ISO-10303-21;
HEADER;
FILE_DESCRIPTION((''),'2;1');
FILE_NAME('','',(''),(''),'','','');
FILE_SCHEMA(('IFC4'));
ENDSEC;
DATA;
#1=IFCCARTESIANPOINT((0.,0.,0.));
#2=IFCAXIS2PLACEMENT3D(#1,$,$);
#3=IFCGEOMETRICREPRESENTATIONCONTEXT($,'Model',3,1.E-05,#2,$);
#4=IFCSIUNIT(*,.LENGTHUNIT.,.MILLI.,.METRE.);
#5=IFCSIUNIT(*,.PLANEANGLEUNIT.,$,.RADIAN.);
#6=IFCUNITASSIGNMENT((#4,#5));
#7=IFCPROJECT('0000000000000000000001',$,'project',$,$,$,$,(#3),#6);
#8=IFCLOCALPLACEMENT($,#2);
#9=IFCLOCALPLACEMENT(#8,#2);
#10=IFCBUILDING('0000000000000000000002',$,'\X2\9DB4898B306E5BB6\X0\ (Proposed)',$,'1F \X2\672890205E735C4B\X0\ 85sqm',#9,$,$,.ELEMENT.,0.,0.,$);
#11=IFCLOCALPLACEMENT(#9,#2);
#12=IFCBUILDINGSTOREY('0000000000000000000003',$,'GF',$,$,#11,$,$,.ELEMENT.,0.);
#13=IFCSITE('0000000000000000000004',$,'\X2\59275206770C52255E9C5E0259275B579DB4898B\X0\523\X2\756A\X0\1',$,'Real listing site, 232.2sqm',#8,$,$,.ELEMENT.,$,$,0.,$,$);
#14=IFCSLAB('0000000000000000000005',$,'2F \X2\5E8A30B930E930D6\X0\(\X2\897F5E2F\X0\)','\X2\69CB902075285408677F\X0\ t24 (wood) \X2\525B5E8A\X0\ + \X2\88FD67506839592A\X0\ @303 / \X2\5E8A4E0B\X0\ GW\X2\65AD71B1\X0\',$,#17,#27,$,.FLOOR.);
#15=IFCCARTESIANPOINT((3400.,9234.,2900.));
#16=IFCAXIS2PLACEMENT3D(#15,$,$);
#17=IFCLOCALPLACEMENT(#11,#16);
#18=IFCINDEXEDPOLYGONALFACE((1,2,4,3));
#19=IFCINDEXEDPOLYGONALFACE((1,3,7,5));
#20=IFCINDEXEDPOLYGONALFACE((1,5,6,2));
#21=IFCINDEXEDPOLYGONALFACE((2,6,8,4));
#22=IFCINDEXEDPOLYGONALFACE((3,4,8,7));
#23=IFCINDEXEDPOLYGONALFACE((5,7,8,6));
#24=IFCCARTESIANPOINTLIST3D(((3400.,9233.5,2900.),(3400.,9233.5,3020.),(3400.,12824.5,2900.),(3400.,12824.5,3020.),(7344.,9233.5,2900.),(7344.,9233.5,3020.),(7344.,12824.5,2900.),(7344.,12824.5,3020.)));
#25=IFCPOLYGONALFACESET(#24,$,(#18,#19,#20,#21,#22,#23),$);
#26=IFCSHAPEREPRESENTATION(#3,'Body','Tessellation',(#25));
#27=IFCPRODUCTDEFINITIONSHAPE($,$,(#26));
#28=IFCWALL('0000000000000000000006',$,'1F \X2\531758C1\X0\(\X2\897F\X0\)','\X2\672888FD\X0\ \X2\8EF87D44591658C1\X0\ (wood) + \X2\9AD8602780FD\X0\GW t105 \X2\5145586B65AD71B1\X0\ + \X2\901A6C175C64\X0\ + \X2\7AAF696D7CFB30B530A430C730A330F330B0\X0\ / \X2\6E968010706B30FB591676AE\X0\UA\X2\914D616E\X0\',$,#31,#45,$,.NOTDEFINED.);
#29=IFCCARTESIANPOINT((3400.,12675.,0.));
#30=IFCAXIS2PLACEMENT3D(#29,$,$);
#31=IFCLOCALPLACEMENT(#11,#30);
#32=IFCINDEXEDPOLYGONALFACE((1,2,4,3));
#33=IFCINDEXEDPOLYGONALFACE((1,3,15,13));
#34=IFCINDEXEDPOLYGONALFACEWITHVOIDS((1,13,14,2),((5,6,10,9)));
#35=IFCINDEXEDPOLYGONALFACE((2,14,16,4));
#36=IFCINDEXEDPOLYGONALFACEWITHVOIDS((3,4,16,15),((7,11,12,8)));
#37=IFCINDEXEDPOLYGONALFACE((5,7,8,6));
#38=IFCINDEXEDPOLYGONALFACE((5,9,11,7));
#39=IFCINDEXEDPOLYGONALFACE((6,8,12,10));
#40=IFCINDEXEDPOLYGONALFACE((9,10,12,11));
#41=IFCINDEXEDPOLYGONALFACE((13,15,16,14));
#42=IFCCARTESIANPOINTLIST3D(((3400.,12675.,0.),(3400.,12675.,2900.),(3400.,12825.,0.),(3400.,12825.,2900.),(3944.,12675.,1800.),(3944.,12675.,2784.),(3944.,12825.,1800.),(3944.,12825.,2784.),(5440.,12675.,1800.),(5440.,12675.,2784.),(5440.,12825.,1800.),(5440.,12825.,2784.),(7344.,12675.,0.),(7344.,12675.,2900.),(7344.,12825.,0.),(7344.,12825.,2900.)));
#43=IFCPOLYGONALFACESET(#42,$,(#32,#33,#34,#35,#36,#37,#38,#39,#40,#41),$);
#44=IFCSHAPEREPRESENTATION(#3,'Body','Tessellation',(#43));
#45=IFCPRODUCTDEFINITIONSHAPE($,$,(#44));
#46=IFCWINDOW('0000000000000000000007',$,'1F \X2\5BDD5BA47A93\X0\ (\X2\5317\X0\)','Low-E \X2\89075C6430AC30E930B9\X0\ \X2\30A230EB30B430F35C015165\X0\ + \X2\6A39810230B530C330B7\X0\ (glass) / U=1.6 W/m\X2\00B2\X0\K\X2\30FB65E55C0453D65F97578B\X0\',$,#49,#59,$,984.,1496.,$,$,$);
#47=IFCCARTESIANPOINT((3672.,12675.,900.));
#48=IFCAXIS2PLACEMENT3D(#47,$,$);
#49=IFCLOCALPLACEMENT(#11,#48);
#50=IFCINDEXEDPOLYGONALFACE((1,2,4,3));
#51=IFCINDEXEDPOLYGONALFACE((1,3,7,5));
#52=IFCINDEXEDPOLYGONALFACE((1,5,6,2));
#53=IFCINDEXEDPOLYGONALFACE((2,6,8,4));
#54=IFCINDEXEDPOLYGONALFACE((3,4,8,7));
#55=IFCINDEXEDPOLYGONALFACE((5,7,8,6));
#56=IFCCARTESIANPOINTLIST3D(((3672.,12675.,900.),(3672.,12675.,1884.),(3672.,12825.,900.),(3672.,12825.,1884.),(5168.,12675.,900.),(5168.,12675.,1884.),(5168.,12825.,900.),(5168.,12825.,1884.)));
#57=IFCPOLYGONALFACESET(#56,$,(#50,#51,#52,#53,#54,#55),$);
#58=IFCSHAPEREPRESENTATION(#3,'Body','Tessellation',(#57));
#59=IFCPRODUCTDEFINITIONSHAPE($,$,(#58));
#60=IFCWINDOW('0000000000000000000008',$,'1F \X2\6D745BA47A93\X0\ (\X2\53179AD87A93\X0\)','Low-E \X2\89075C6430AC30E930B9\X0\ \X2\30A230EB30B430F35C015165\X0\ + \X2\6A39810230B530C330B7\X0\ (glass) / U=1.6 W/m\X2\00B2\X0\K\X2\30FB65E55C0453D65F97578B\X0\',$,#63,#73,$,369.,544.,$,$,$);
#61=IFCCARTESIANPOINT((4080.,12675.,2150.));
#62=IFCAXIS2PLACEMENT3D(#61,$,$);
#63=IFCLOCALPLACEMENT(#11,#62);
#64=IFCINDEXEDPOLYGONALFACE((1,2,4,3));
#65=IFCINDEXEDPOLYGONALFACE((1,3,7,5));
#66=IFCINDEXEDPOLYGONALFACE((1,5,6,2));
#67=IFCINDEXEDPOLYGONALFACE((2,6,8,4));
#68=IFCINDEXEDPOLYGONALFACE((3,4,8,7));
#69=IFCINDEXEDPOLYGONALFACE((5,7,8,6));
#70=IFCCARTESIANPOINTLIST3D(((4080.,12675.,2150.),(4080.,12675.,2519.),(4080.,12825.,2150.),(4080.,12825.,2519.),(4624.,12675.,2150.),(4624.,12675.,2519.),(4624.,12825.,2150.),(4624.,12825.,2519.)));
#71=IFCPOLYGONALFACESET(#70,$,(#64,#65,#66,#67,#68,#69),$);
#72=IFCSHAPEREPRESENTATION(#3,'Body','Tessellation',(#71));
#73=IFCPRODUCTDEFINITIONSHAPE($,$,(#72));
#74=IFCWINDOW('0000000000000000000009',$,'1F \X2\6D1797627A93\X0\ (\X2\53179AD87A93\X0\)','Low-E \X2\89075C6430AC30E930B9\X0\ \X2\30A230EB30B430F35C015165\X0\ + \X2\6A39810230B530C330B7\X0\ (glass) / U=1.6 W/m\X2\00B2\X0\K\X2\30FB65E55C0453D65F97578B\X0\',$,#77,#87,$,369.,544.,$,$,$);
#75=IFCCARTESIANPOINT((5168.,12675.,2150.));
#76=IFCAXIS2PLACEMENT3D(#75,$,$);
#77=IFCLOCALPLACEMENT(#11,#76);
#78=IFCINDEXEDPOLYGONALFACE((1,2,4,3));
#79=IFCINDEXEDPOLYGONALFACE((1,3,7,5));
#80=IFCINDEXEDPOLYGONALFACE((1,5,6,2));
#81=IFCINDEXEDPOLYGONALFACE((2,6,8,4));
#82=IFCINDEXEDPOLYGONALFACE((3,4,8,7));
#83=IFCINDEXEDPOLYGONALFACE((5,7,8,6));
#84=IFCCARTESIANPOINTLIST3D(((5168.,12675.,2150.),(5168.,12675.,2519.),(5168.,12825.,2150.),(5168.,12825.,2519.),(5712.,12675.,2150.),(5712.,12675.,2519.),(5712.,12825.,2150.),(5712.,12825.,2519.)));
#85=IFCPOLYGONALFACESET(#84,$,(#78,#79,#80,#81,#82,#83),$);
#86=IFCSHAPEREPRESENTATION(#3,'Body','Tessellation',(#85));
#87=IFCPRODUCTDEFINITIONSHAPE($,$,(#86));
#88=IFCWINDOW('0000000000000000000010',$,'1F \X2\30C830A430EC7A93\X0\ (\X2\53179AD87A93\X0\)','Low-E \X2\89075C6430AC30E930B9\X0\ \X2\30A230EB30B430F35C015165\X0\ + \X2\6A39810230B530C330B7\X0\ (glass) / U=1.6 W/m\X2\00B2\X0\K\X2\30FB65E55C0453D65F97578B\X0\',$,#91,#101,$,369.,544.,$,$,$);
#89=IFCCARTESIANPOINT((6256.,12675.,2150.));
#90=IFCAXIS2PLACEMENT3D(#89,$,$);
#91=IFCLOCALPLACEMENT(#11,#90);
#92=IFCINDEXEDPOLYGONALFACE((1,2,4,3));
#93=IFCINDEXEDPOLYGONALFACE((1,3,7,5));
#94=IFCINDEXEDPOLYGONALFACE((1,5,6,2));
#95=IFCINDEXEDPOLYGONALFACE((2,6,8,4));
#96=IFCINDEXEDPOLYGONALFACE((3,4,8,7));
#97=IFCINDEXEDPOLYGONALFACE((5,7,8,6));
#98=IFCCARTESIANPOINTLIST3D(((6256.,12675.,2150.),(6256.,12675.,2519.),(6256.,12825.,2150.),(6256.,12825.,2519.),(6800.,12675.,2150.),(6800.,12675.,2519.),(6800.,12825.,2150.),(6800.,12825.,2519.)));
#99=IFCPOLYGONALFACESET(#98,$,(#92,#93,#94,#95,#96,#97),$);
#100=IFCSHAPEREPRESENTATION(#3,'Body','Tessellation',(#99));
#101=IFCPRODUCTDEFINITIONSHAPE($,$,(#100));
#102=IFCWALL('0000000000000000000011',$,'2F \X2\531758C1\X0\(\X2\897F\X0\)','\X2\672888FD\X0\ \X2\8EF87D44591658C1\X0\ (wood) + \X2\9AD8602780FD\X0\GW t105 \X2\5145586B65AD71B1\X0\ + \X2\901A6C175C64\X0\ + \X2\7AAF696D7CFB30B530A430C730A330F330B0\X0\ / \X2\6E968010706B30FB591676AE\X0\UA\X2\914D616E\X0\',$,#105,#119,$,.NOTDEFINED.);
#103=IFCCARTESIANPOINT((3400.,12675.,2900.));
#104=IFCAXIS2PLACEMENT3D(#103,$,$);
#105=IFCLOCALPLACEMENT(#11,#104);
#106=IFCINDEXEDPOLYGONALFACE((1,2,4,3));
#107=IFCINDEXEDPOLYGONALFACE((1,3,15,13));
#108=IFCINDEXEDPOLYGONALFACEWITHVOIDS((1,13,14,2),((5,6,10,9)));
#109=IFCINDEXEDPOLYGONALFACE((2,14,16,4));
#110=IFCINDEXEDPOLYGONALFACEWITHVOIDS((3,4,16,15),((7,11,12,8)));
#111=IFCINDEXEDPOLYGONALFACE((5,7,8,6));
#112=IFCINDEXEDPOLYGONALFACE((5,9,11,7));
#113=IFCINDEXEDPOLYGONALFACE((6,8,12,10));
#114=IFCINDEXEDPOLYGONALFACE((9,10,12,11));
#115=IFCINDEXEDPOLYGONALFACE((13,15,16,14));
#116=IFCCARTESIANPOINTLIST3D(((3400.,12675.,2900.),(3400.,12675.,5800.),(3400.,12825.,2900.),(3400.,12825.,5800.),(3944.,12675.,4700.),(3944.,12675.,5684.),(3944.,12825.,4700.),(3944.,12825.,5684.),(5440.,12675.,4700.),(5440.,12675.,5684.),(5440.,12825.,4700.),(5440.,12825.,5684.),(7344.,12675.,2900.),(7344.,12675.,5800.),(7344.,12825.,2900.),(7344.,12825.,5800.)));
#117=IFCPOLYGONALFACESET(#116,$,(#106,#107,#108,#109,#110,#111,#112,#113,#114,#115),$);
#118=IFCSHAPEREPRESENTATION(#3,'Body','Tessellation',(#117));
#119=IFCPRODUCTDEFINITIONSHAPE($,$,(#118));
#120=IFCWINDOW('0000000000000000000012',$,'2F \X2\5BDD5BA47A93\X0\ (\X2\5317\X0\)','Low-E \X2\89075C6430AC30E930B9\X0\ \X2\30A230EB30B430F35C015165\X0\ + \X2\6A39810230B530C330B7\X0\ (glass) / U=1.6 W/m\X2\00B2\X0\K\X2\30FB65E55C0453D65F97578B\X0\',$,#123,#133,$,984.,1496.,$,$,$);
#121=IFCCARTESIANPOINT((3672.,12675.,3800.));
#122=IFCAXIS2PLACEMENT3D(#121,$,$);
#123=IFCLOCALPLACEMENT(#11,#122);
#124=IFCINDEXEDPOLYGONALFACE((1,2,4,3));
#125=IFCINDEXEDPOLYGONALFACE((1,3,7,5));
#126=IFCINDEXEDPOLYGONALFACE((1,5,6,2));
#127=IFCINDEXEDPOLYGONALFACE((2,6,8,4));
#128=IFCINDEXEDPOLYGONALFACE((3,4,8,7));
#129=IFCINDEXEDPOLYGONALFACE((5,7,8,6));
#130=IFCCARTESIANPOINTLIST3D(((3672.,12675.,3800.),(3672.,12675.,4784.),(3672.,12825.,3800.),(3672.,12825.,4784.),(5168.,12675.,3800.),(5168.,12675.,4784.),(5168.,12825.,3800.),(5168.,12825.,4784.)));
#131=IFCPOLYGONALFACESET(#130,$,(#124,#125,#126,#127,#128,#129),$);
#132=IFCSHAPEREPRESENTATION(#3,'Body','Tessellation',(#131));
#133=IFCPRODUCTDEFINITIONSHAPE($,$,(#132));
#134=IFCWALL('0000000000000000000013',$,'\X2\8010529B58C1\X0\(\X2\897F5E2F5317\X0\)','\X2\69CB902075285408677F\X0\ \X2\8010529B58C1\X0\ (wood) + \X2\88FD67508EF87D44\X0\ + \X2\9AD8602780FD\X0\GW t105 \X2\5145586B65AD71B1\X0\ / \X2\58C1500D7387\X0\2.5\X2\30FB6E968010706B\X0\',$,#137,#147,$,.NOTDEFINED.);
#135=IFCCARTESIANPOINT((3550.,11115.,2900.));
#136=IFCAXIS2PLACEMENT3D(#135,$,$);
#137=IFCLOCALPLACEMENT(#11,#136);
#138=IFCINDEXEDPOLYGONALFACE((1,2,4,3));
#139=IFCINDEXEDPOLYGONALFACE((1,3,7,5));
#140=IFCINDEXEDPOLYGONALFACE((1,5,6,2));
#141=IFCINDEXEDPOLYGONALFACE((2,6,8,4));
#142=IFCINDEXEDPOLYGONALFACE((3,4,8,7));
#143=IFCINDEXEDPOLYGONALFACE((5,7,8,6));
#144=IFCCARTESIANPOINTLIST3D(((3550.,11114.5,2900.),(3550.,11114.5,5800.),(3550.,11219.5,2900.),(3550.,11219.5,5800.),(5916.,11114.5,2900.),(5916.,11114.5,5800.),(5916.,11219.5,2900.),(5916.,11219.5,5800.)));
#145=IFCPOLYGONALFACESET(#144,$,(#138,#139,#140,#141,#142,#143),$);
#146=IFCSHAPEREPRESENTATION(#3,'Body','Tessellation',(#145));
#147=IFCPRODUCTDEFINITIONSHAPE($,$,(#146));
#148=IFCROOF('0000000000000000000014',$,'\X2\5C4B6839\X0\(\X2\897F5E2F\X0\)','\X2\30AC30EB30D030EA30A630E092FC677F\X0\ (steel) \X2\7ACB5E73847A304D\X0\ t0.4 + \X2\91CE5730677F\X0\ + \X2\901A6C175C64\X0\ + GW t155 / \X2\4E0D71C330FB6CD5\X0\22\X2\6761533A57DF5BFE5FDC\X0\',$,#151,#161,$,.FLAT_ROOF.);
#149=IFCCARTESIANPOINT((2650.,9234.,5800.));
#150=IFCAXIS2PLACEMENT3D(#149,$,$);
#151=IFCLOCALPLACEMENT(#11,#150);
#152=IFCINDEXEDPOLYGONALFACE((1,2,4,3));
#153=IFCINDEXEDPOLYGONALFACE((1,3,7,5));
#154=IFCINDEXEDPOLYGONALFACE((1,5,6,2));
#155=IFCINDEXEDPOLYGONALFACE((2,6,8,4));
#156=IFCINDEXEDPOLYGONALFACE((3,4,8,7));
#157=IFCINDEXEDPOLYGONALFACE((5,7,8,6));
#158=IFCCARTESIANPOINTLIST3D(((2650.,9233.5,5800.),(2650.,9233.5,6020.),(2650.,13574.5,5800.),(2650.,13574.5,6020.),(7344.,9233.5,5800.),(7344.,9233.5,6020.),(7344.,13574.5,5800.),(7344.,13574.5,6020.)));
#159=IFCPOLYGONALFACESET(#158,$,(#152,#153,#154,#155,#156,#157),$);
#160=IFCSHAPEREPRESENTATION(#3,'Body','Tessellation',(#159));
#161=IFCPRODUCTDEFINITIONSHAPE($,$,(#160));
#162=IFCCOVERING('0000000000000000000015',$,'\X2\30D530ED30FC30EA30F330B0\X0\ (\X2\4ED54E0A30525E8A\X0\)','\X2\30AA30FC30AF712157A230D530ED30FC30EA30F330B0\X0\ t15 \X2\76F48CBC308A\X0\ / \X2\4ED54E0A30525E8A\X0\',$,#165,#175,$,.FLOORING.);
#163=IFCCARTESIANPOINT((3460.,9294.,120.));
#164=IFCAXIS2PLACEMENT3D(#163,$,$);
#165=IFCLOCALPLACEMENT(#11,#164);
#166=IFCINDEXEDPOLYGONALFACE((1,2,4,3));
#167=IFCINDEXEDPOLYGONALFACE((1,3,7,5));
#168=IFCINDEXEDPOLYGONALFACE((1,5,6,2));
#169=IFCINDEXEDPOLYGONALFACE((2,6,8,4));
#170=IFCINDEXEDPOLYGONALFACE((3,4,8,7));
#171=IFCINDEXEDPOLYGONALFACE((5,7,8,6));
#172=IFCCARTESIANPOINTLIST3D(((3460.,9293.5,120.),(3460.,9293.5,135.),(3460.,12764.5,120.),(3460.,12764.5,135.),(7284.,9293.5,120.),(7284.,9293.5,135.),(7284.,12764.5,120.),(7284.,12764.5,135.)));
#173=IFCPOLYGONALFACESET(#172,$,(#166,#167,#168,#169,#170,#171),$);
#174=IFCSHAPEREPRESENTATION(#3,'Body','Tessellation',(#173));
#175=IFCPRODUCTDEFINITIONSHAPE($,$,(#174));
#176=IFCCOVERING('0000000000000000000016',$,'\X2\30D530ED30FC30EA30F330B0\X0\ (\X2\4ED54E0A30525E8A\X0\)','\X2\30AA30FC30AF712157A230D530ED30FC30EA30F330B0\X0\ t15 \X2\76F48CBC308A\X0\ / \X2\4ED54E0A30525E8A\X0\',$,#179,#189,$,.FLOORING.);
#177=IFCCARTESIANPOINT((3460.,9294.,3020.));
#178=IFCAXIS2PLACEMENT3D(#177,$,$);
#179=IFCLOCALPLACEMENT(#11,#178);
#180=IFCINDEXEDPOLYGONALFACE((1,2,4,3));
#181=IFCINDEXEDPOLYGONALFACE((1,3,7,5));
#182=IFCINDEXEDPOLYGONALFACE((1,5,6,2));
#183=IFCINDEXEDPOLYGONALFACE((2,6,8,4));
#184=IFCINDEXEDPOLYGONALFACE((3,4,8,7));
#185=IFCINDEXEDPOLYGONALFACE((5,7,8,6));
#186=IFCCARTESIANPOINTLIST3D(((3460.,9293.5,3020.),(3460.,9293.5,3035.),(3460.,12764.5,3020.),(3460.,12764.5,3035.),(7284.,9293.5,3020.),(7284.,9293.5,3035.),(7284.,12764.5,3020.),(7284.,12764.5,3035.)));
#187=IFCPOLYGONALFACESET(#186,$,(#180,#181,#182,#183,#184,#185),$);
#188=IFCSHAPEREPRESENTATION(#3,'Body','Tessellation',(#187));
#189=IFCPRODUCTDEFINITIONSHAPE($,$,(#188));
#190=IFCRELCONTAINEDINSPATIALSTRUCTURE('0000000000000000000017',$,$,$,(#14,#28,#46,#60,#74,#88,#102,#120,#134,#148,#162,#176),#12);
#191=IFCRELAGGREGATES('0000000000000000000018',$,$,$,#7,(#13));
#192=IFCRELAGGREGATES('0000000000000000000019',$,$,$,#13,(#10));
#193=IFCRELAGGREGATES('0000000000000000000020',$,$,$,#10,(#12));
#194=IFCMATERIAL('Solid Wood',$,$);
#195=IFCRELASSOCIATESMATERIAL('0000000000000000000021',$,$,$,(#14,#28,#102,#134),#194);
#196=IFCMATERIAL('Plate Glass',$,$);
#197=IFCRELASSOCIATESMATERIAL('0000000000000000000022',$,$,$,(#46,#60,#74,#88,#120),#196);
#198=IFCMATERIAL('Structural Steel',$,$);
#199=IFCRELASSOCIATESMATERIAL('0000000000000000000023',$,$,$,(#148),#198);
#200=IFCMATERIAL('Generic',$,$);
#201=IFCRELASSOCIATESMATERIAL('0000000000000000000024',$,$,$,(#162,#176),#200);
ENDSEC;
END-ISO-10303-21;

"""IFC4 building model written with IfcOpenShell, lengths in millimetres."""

from ifc_helpers import new_model, si_unit, frame, frame_2d, origin, place, context, project, spatial, rectangle, extrude, material, element, fill, save


model = new_model("IFC4")

# Units and contexts
model_context = context("Model", 3, precision=1e-05, world=origin())
ifc_project = project(units=[si_unit("LENGTHUNIT", "METRE", prefix="MILLI"), si_unit("PLANEANGLEUNIT", "RADIAN")], contexts=[model_context])

# Site, building, storey
site_placement = place(None, origin())
site = spatial("IfcSite", under=ifc_project, at=site_placement, Name="大分県別府市大字鶴見523番1", ObjectType="Real listing site, 232.2sqm", CompositionType="ELEMENT", RefElevation=0.0)
building_placement = place(site_placement, origin())
building = spatial("IfcBuilding", under=site, at=building_placement, Name="鶴見の家 (Proposed)", ObjectType="1F 木造平屋 85sqm", CompositionType="ELEMENT", ElevationOfRefHeight=0.0, ElevationOfTerrain=0.0)
storey_placement = place(building_placement, origin())
storey = spatial("IfcBuildingStorey", under=building, at=storey_placement, Name="GF", CompositionType="ELEMENT", Elevation=0.0)

# Slab
ifc_material_1 = material(Name="Solid Wood")
slab_1_placement = place(storey_placement, frame((3400.0, 9234.0, 2900.0)))
element("IfcSlab", 1, at=slab_1_placement, inside=storey, material=ifc_material_1, Name="2F 床スラブ(西帯)", Description="構造用合板 t24 (wood) 剛床 + 製材根太 @303 / 床下 GW断熱", PredefinedType="FLOOR", context=model_context, shape_type="SweptSolid", body=[
    extrude(rectangle(XDim=3944.0, YDim=3591.0, at=frame_2d((1972.0, 1795.0))), frame((3400.0, 9234.0, 2900.0)), (0.0, 0.0, 1.0), 120.0),
])

# Wall, openings, windows
wall_1_placement = place(storey_placement, frame((3400.0, 12675.0, 0.0)))
wall_1 = element("IfcWall", 2, at=wall_1_placement, inside=storey, material=ifc_material_1, Name="1F 北壁(西)", Description="木製 軸組外壁 (wood) + 高性能GW t105 充填断熱 + 通気層 + 窯業系サイディング / 準耐火・外皮UA配慮", PredefinedType="NOTDEFINED", context=model_context, shape_type="SweptSolid", body=[
    extrude(rectangle(XDim=3944.0, YDim=150.0, at=frame_2d((1972.0, 75.0))), frame((3400.0, 12675.0, 0.0)), (0.0, 0.0, 1.0), 2900.0),
])
opening_1_placement = place(storey_placement, frame((3672.0, 12675.0, 900.0)))
opening_1 = element("IfcOpeningElement", 3, at=opening_1_placement, cuts=wall_1, PredefinedType="NOTDEFINED", context=model_context, shape_type="SweptSolid", body=[
    extrude(rectangle(XDim=1496.0, YDim=150.0, at=frame_2d((748.0, 75.0))), frame((3672.0, 12675.0, 900.0)), (0.0, 0.0, 1.0), 984.0),
])
opening_2_placement = place(storey_placement, frame((4080.0, 12675.0, 2150.0)))
opening_2 = element("IfcOpeningElement", 4, at=opening_2_placement, cuts=wall_1, PredefinedType="NOTDEFINED", context=model_context, shape_type="SweptSolid", body=[
    extrude(rectangle(XDim=544.0, YDim=150.0, at=frame_2d((272.0, 75.0))), frame((4080.0, 12675.0, 2150.0)), (0.0, 0.0, 1.0), 369.0),
])
opening_3_placement = place(storey_placement, frame((5168.0, 12675.0, 2150.0)))
opening_3 = element("IfcOpeningElement", 5, at=opening_3_placement, cuts=wall_1, PredefinedType="NOTDEFINED", context=model_context, shape_type="SweptSolid", body=[
    extrude(rectangle(XDim=544.0, YDim=150.0, at=frame_2d((272.0, 75.0))), frame((5168.0, 12675.0, 2150.0)), (0.0, 0.0, 1.0), 369.0),
])
opening_4_placement = place(storey_placement, frame((6256.0, 12675.0, 2150.0)))
opening_4 = element("IfcOpeningElement", 6, at=opening_4_placement, cuts=wall_1, PredefinedType="NOTDEFINED", context=model_context, shape_type="SweptSolid", body=[
    extrude(rectangle(XDim=544.0, YDim=150.0, at=frame_2d((272.0, 75.0))), frame((6256.0, 12675.0, 2150.0)), (0.0, 0.0, 1.0), 369.0),
])
ifc_material_2 = material(Name="Plate Glass")
window_1_placement = place(storey_placement, frame((3672.0, 12675.0, 900.0)))
window_1 = element("IfcWindow", 7, at=window_1_placement, inside=storey, material=ifc_material_2, Name="1F 寝室窓 (北)", Description="Low-E 複層ガラス アルゴン封入 + 樹脂サッシ (glass) / U=1.6 W/m²K・日射取得型", OverallHeight=984.0, OverallWidth=1496.0, context=model_context, shape_type="SweptSolid", body=[
    extrude(rectangle(XDim=1496.0, YDim=150.0, at=frame_2d((748.0, 75.0))), frame((3672.0, 12675.0, 900.0)), (0.0, 0.0, 1.0), 984.0),
])
fill(opening_1, window_1)
window_2_placement = place(storey_placement, frame((4080.0, 12675.0, 2150.0)))
window_2 = element("IfcWindow", 8, at=window_2_placement, inside=storey, material=ifc_material_2, Name="1F 浴室窓 (北高窓)", Description="Low-E 複層ガラス アルゴン封入 + 樹脂サッシ (glass) / U=1.6 W/m²K・日射取得型", OverallHeight=369.0, OverallWidth=544.0, context=model_context, shape_type="SweptSolid", body=[
    extrude(rectangle(XDim=544.0, YDim=150.0, at=frame_2d((272.0, 75.0))), frame((4080.0, 12675.0, 2150.0)), (0.0, 0.0, 1.0), 369.0),
])
fill(opening_2, window_2)
window_3_placement = place(storey_placement, frame((5168.0, 12675.0, 2150.0)))
window_3 = element("IfcWindow", 9, at=window_3_placement, inside=storey, material=ifc_material_2, Name="1F 洗面窓 (北高窓)", Description="Low-E 複層ガラス アルゴン封入 + 樹脂サッシ (glass) / U=1.6 W/m²K・日射取得型", OverallHeight=369.0, OverallWidth=544.0, context=model_context, shape_type="SweptSolid", body=[
    extrude(rectangle(XDim=544.0, YDim=150.0, at=frame_2d((272.0, 75.0))), frame((5168.0, 12675.0, 2150.0)), (0.0, 0.0, 1.0), 369.0),
])
fill(opening_3, window_3)
window_4_placement = place(storey_placement, frame((6256.0, 12675.0, 2150.0)))
window_4 = element("IfcWindow", 10, at=window_4_placement, inside=storey, material=ifc_material_2, Name="1F トイレ窓 (北高窓)", Description="Low-E 複層ガラス アルゴン封入 + 樹脂サッシ (glass) / U=1.6 W/m²K・日射取得型", OverallHeight=369.0, OverallWidth=544.0, context=model_context, shape_type="SweptSolid", body=[
    extrude(rectangle(XDim=544.0, YDim=150.0, at=frame_2d((272.0, 75.0))), frame((6256.0, 12675.0, 2150.0)), (0.0, 0.0, 1.0), 369.0),
])
fill(opening_4, window_4)

# Wall, opening, window
wall_2_placement = place(storey_placement, frame((3400.0, 12675.0, 2900.0)))
wall_2 = element("IfcWall", 11, at=wall_2_placement, inside=storey, material=ifc_material_1, Name="2F 北壁(西)", Description="木製 軸組外壁 (wood) + 高性能GW t105 充填断熱 + 通気層 + 窯業系サイディング / 準耐火・外皮UA配慮", PredefinedType="NOTDEFINED", context=model_context, shape_type="SweptSolid", body=[
    extrude(rectangle(XDim=3944.0, YDim=150.0, at=frame_2d((1972.0, 75.0))), frame((3400.0, 12675.0, 2900.0)), (0.0, 0.0, 1.0), 2900.0),
])
opening_5_placement = place(storey_placement, frame((3672.0, 12675.0, 3800.0)))
opening_5 = element("IfcOpeningElement", 12, at=opening_5_placement, cuts=wall_2, PredefinedType="NOTDEFINED", context=model_context, shape_type="SweptSolid", body=[
    extrude(rectangle(XDim=1496.0, YDim=150.0, at=frame_2d((748.0, 75.0))), frame((3672.0, 12675.0, 3800.0)), (0.0, 0.0, 1.0), 984.0),
])
window_5_placement = place(storey_placement, frame((3672.0, 12675.0, 3800.0)))
window_5 = element("IfcWindow", 13, at=window_5_placement, inside=storey, material=ifc_material_2, Name="2F 寝室窓 (北)", Description="Low-E 複層ガラス アルゴン封入 + 樹脂サッシ (glass) / U=1.6 W/m²K・日射取得型", OverallHeight=984.0, OverallWidth=1496.0, context=model_context, shape_type="SweptSolid", body=[
    extrude(rectangle(XDim=1496.0, YDim=150.0, at=frame_2d((748.0, 75.0))), frame((3672.0, 12675.0, 3800.0)), (0.0, 0.0, 1.0), 984.0),
])
fill(opening_5, window_5)

# Wall
wall_3_placement = place(storey_placement, frame((3550.0, 11115.0, 2900.0)))
element("IfcWall", 14, at=wall_3_placement, inside=storey, material=ifc_material_1, Name="耐力壁(西帯北)", Description="構造用合板 耐力壁 (wood) + 製材軸組 + 高性能GW t105 充填断熱 / 壁倍率2.5・準耐火", PredefinedType="NOTDEFINED", context=model_context, shape_type="SweptSolid", body=[
    extrude(rectangle(XDim=2366.0, YDim=105.0, at=frame_2d((1183.0, 52.0))), frame((3550.0, 11115.0, 2900.0)), (0.0, 0.0, 1.0), 2900.0),
])

# Roof
ifc_material_3 = material(Name="Structural Steel")
for number, where, name in (
    (15, (2650.0, 9234.0, 5800.0), "屋根(西帯)"),
):
    element("IfcRoof", number, at=place(storey_placement, frame(where)), inside=storey, material=ifc_material_3, Name=name, Description="ガルバリウム鋼板 (steel) 立平葺き t0.4 + 野地板 + 通気層 + GW t155 / 不燃・法22条区域対応", PredefinedType="FLAT_ROOF", context=model_context, shape_type="SweptSolid", body=[
        extrude(rectangle(XDim=4694.0, YDim=4341.0, at=frame_2d((2347.0, 2170.0))), frame((2650.0, 9234.0, 5800.0)), (0.0, 0.0, 1.0), 220.0),
    ])

# Coverings
ifc_material_4 = material(Name="Generic")
covering_1_placement = place(storey_placement, frame((3460.0, 9294.0, 120.0)))
element("IfcCovering", 16, at=covering_1_placement, inside=storey, material=ifc_material_4, Name="フローリング (仕上げ床)", Description="オーク無垢フローリング t15 直貼り / 仕上げ床", PredefinedType="FLOORING", context=model_context, shape_type="SweptSolid", body=[
    extrude(rectangle(XDim=3824.0, YDim=3471.0, at=frame_2d((1912.0, 1735.0))), frame((3460.0, 9294.0, 120.0)), (0.0, 0.0, 1.0), 15.0),
])
covering_2_placement = place(storey_placement, frame((3460.0, 9294.0, 3020.0)))
element("IfcCovering", 17, at=covering_2_placement, inside=storey, material=ifc_material_4, Name="フローリング (仕上げ床)", Description="オーク無垢フローリング t15 直貼り / 仕上げ床", PredefinedType="FLOORING", context=model_context, shape_type="SweptSolid", body=[
    extrude(rectangle(XDim=3824.0, YDim=3471.0, at=frame_2d((1912.0, 1735.0))), frame((3460.0, 9294.0, 3020.0)), (0.0, 0.0, 1.0), 15.0),
])

save(model, "model.ifc")
